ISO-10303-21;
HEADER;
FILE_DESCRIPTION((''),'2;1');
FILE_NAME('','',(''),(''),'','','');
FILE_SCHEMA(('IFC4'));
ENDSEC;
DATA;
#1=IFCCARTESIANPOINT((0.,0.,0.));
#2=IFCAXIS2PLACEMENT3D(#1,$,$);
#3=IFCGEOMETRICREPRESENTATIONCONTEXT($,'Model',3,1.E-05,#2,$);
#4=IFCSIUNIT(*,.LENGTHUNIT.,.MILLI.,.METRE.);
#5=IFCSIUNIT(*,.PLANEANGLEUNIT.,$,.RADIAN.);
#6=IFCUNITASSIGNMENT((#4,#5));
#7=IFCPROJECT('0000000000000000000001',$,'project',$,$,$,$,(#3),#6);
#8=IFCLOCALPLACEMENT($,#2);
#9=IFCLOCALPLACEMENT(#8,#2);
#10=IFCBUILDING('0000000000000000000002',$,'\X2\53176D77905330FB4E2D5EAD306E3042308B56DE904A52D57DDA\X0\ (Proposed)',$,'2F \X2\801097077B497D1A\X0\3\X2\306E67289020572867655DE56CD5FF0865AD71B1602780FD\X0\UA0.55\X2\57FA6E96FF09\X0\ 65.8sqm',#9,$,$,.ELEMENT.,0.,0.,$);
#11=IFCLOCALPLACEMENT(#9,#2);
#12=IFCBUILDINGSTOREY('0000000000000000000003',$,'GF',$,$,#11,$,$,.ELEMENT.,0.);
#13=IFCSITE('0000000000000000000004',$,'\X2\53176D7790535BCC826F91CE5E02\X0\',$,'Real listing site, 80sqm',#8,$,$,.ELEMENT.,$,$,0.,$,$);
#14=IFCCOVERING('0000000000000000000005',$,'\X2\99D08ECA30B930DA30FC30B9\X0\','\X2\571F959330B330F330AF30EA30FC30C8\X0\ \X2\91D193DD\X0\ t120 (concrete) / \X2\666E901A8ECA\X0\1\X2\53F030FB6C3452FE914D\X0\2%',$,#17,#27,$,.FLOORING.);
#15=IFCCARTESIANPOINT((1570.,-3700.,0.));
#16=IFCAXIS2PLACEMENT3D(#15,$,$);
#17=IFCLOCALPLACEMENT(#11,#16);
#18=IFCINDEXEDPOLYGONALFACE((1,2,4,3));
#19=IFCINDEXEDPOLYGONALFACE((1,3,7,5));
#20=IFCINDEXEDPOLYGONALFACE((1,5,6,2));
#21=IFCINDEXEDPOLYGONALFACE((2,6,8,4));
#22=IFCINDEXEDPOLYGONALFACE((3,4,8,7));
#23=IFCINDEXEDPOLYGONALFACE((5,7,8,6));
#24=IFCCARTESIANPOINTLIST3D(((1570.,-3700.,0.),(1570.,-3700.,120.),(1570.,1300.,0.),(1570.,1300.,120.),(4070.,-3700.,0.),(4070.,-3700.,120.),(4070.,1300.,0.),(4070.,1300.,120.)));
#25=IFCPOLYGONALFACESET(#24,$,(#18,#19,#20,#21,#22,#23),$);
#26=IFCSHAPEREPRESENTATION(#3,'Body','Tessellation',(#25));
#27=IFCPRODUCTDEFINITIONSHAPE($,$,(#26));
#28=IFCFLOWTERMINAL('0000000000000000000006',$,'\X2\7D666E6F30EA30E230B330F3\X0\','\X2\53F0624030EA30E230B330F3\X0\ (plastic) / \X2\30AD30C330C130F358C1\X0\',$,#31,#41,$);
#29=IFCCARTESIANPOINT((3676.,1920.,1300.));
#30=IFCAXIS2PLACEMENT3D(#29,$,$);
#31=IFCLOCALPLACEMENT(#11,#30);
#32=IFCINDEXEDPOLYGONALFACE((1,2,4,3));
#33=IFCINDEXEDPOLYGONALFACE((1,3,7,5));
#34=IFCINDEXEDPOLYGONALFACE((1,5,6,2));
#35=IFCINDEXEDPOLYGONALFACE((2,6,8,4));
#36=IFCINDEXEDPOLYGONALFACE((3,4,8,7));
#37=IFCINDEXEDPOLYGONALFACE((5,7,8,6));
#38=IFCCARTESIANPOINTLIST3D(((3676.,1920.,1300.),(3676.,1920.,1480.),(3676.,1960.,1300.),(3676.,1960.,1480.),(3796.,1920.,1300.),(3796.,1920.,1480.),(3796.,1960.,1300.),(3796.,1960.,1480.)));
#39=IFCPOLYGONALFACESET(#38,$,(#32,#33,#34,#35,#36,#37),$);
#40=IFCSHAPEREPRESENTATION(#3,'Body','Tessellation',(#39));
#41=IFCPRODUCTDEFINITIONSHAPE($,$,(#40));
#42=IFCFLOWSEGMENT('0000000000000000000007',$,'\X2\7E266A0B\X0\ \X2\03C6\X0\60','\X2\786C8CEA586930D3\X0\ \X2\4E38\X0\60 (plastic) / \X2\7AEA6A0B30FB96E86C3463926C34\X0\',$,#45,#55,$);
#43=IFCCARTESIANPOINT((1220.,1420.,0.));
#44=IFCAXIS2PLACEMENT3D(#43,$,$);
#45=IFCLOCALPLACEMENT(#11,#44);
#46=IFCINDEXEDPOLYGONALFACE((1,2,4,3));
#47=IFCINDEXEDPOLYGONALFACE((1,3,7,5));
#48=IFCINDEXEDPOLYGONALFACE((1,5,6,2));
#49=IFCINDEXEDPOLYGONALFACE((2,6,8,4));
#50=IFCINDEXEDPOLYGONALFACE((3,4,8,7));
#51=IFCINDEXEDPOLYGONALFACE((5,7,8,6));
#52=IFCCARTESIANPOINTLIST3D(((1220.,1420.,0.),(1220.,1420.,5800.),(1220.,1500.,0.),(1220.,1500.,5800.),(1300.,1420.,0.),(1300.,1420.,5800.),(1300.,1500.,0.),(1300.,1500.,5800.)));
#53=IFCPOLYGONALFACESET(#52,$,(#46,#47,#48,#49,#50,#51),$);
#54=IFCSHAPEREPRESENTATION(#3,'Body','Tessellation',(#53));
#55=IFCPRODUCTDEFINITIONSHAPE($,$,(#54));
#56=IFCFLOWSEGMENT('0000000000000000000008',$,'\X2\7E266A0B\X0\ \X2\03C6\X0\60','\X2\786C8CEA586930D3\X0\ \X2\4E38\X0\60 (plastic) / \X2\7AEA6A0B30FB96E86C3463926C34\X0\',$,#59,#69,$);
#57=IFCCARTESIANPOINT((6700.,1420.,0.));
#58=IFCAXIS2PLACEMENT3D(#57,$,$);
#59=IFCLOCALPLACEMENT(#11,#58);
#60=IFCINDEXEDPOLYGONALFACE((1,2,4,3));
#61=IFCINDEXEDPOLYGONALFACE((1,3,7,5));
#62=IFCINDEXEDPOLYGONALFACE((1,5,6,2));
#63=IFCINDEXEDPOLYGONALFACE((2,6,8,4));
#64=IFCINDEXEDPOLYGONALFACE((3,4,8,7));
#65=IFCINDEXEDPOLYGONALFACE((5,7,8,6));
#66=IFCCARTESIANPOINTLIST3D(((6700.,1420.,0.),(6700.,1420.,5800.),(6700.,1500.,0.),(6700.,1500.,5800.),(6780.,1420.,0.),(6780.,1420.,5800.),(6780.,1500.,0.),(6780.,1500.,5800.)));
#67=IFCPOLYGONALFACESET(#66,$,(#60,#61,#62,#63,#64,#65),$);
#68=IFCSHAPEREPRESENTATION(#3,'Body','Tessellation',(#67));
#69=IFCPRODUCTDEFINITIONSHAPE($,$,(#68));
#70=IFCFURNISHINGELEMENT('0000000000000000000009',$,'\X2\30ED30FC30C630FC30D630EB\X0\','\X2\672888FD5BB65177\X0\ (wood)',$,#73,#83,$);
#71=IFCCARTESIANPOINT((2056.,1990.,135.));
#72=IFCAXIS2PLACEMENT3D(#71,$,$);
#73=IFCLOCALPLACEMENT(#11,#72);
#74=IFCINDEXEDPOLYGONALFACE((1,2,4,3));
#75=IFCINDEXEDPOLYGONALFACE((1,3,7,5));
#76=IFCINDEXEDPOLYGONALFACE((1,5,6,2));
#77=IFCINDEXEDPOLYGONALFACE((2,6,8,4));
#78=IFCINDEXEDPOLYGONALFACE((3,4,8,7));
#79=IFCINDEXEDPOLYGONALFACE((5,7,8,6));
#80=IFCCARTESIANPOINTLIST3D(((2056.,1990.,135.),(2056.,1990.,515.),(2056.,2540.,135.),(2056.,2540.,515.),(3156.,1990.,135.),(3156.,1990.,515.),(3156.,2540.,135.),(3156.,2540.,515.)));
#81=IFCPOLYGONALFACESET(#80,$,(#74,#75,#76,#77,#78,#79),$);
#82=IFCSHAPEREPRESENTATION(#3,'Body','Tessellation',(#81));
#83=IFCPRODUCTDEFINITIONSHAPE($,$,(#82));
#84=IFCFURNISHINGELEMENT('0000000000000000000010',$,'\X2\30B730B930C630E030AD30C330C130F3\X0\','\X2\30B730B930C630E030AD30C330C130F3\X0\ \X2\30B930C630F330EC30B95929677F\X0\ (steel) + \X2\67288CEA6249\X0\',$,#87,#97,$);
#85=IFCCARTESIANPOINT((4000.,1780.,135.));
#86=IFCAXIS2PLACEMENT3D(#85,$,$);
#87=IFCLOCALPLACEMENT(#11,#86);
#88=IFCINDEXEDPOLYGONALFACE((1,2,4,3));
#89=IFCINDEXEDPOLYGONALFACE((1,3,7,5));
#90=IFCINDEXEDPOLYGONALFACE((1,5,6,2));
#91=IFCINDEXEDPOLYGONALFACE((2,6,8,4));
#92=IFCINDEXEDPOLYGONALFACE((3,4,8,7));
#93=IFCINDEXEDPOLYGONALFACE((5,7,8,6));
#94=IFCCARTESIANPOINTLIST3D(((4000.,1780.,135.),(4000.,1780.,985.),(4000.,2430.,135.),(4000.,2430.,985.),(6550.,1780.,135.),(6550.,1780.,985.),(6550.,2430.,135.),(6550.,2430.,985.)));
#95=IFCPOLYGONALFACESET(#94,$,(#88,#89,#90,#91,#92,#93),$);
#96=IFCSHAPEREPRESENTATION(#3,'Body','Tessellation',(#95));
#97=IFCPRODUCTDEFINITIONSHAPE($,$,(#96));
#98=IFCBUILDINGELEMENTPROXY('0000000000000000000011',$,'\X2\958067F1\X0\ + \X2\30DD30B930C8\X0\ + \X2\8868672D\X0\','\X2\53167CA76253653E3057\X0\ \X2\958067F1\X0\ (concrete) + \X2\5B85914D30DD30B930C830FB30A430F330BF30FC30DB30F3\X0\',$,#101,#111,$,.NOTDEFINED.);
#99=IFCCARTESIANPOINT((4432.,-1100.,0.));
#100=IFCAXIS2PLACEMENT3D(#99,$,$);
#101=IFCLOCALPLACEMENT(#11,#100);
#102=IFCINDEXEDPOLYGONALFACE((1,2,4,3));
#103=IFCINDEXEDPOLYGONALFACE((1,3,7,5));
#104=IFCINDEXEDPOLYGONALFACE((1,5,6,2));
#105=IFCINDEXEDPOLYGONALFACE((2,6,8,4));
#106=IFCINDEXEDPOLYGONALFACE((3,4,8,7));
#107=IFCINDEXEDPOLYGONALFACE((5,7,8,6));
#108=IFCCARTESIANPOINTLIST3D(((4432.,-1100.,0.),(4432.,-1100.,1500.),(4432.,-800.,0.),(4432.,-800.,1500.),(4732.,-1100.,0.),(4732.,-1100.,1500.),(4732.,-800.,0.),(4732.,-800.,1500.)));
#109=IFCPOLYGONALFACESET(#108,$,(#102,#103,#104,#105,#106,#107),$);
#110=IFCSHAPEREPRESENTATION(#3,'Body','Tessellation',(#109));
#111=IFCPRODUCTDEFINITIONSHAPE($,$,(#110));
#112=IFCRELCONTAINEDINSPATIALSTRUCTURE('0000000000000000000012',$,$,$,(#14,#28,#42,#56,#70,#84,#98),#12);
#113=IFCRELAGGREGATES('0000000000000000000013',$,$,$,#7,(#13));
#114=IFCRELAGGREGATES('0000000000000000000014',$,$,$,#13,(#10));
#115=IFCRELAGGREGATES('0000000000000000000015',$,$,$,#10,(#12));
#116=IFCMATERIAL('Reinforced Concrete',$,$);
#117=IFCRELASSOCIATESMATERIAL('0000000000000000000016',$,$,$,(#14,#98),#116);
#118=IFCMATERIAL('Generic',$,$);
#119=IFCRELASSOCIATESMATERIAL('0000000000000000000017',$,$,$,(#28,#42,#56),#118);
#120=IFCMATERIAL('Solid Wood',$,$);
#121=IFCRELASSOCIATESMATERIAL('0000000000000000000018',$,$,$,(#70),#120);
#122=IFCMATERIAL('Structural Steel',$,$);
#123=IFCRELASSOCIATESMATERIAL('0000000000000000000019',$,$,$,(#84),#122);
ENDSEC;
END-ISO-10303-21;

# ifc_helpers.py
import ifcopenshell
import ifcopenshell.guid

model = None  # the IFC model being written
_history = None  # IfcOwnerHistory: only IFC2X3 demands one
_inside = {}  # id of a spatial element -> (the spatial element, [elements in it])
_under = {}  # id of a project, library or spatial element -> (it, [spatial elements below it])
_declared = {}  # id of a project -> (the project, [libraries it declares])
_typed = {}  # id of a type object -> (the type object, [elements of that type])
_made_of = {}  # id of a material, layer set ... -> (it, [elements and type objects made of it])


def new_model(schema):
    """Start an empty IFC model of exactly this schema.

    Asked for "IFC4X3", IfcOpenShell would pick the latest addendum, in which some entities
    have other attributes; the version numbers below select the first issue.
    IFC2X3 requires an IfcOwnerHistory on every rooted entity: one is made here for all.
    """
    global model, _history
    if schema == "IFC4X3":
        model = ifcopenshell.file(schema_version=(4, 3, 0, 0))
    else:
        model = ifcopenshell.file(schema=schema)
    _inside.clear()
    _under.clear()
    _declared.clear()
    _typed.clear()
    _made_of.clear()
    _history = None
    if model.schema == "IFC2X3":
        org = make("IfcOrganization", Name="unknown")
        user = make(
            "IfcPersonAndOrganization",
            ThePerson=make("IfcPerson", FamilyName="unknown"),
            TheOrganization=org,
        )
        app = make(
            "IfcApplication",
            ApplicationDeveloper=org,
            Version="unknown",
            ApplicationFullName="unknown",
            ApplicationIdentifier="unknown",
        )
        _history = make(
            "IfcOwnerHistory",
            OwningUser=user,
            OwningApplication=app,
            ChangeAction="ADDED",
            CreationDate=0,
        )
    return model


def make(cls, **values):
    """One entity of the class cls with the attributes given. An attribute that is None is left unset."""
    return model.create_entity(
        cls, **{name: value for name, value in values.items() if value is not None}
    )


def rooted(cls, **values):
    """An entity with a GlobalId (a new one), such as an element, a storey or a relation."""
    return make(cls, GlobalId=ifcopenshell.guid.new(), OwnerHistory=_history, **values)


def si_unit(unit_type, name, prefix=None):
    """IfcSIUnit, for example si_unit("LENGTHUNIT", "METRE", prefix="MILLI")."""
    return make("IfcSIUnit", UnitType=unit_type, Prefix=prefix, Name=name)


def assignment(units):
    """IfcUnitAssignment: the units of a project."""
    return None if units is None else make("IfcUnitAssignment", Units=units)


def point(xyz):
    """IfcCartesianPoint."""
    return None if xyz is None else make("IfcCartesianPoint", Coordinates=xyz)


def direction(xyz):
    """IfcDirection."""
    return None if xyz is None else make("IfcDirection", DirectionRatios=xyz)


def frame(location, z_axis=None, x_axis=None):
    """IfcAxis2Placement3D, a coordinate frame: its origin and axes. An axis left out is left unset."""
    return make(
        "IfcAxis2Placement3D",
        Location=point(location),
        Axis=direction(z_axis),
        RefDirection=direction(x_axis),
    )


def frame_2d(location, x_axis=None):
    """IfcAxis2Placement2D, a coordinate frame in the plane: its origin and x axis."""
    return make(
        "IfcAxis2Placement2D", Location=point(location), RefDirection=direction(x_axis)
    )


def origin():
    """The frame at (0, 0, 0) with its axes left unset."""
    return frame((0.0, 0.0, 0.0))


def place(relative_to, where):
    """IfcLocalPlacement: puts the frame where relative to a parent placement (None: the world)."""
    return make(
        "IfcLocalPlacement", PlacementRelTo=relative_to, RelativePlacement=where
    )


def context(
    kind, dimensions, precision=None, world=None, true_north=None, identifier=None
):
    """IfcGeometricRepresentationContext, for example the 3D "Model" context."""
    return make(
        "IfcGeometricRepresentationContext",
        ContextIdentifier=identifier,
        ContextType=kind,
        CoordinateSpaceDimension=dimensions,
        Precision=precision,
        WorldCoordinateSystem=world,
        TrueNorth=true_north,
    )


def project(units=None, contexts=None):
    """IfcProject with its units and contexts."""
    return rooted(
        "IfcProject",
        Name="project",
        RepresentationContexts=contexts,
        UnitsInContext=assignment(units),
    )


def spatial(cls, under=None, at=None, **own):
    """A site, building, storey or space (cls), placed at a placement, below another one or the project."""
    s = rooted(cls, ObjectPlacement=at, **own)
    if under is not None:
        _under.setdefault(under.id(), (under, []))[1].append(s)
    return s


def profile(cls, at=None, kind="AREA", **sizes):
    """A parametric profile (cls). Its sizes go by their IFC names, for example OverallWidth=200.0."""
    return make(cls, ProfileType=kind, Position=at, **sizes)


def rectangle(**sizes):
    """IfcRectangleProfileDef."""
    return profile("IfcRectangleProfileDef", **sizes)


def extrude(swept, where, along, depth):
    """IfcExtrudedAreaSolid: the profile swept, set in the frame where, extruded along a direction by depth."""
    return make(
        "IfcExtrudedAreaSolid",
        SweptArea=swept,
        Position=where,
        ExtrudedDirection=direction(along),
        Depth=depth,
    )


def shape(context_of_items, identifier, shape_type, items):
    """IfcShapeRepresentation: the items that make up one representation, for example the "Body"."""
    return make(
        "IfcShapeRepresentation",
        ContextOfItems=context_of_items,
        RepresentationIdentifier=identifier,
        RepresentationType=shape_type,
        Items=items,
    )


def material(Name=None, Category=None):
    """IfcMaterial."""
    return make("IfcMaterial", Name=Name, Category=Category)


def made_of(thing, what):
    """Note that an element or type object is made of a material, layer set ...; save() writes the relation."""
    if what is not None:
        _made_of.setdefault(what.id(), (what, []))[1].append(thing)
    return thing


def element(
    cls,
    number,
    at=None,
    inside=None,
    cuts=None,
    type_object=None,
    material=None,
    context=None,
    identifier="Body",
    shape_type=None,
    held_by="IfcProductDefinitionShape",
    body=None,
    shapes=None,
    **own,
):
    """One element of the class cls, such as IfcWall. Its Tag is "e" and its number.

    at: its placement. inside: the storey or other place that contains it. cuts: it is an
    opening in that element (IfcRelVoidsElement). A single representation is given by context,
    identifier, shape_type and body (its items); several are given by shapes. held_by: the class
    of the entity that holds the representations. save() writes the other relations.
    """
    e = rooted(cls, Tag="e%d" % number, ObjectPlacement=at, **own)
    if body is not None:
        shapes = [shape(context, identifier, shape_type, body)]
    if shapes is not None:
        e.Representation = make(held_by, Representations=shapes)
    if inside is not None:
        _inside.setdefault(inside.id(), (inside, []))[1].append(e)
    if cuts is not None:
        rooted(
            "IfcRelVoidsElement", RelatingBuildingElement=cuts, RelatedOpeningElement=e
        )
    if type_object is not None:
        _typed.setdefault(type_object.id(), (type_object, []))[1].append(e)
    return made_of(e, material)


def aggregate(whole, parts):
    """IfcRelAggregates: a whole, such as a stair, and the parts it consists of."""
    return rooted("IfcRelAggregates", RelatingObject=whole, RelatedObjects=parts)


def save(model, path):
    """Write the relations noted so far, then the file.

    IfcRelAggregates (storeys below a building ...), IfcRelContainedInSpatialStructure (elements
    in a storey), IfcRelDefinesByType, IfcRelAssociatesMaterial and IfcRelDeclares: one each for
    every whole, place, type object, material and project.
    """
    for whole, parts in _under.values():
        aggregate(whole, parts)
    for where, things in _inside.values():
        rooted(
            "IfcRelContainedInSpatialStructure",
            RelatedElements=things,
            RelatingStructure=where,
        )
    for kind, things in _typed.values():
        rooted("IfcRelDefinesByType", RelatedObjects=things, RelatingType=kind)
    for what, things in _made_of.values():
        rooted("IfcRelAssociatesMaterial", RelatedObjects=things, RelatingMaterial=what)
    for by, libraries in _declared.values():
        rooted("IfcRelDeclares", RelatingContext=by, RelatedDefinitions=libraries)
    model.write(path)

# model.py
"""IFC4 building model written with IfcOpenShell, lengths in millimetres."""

from ifc_helpers import new_model, si_unit, frame, frame_2d, origin, place, context, project, spatial, rectangle, extrude, material, element, save


model = new_model("IFC4")

# Units and contexts
model_context = context("Model", 3, precision=1e-05, world=origin())
ifc_project = project(units=[si_unit("LENGTHUNIT", "METRE", prefix="MILLI"), si_unit("PLANEANGLEUNIT", "RADIAN")], contexts=[model_context])

# Site, building, storey
site_placement = place(None, origin())
site = spatial("IfcSite", under=ifc_project, at=site_placement, Name="北海道富良野市", ObjectType="Real listing site, 80sqm", CompositionType="ELEMENT", RefElevation=0.0)
building_placement = place(site_placement, origin())
building = spatial("IfcBuilding", under=site, at=building_placement, Name="北海道・中庭のある回遊動線 (Proposed)", ObjectType="2F 耐震等級3の木造在来工法（断熱性能UA0.55基準） 65.8sqm", CompositionType="ELEMENT", ElevationOfRefHeight=0.0, ElevationOfTerrain=0.0)
storey_placement = place(building_placement, origin())
storey = spatial("IfcBuildingStorey", under=building, at=storey_placement, Name="GF", CompositionType="ELEMENT", Elevation=0.0)

# Shared definitions
ifc_material_1 = material(Name="Solid Wood")

# Shared definitions
ifc_material_2 = material(Name="Reinforced Concrete")

# Covering
ifc_material_3 = material(Name="Generic")
covering_1_placement = place(storey_placement, frame((1570.0, -3700.0, 0.0)))
element("IfcCovering", 1, at=covering_1_placement, inside=storey, material=ifc_material_2, Name="駐車スペース", Description="土間コンクリート 金鏝 t120 (concrete) / 普通車1台・水勾配2%", PredefinedType="FLOORING", context=model_context, shape_type="SweptSolid", body=[
    extrude(rectangle(XDim=2500.0, YDim=5000.0, at=frame_2d((1250.0, 2500.0))), frame((1570.0, -3700.0, 0.0)), (0.0, 0.0, 1.0), 120.0),
])

# Flow terminal
flow_terminal_placement = place(storey_placement, frame((3676.0, 1920.0, 1300.0)))
element("IfcFlowTerminal", 2, at=flow_terminal_placement, inside=storey, material=ifc_material_3, Name="給湯リモコン", Description="台所リモコン (plastic) / キッチン壁", context=model_context, shape_type="SweptSolid", body=[
    extrude(rectangle(XDim=120.0, YDim=40.0, at=frame_2d((60.0, 20.0))), frame((3676.0, 1920.0, 1300.0)), (0.0, 0.0, 1.0), 180.0),
])

# Flow segments
flow_segment_1_placement = place(storey_placement, frame((1220.0, 1420.0, 0.0)))
element("IfcFlowSegment", 3, at=flow_segment_1_placement, inside=storey, material=ifc_material_3, Name="縦樋 φ60", Description="硬質塩ビ 丸60 (plastic) / 竪樋・雨水排水", context=model_context, shape_type="SweptSolid", body=[
    extrude(rectangle(XDim=80.0, YDim=80.0, at=frame_2d((40.0, 40.0))), frame((1220.0, 1420.0, 0.0)), (0.0, 0.0, 1.0), 5800.0),
])
flow_segment_2_placement = place(storey_placement, frame((6700.0, 1420.0, 0.0)))
element("IfcFlowSegment", 4, at=flow_segment_2_placement, inside=storey, material=ifc_material_3, Name="縦樋 φ60", Description="硬質塩ビ 丸60 (plastic) / 竪樋・雨水排水", context=model_context, shape_type="SweptSolid", body=[
    extrude(rectangle(XDim=80.0, YDim=80.0, at=frame_2d((40.0, 40.0))), frame((6700.0, 1420.0, 0.0)), (0.0, 0.0, 1.0), 5800.0),
])

# Furnishing elements
furnishing_1_placement = place(storey_placement, frame((2056.0, 1990.0, 135.0)))
element("IfcFurnishingElement", 5, at=furnishing_1_placement, inside=storey, material=ifc_material_1, Name="ローテーブル", Description="木製家具 (wood)", context=model_context, shape_type="SweptSolid", body=[
    extrude(rectangle(XDim=1100.0, YDim=550.0, at=frame_2d((550.0, 275.0))), frame((2056.0, 1990.0, 135.0)), (0.0, 0.0, 1.0), 380.0),
])
ifc_material_4 = material(Name="Structural Steel")
furnishing_2_placement = place(storey_placement, frame((4000.0, 1780.0, 135.0)))
element("IfcFurnishingElement", 6, at=furnishing_2_placement, inside=storey, material=ifc_material_4, Name="システムキッチン", Description="システムキッチン ステンレス天板 (steel) + 木質扉", context=model_context, shape_type="SweptSolid", body=[
    extrude(rectangle(XDim=2550.0, YDim=650.0, at=frame_2d((1275.0, 325.0))), frame((4000.0, 1780.0, 135.0)), (0.0, 0.0, 1.0), 850.0),
])

# Building element proxy
proxy_placement = place(storey_placement, frame((4432.0, -1100.0, 0.0)))
element("IfcBuildingElementProxy", 7, at=proxy_placement, inside=storey, material=ifc_material_2, Name="門柱 + ポスト + 表札", Description="化粧打放し 門柱 (concrete) + 宅配ポスト・インターホン", PredefinedType="NOTDEFINED", context=model_context, shape_type="SweptSolid", body=[
    extrude(rectangle(XDim=300.0, YDim=300.0, at=frame_2d((150.0, 150.0))), frame((4432.0, -1100.0, 0.0)), (0.0, 0.0, 1.0), 1500.0),
])

save(model, "model.ifc")
